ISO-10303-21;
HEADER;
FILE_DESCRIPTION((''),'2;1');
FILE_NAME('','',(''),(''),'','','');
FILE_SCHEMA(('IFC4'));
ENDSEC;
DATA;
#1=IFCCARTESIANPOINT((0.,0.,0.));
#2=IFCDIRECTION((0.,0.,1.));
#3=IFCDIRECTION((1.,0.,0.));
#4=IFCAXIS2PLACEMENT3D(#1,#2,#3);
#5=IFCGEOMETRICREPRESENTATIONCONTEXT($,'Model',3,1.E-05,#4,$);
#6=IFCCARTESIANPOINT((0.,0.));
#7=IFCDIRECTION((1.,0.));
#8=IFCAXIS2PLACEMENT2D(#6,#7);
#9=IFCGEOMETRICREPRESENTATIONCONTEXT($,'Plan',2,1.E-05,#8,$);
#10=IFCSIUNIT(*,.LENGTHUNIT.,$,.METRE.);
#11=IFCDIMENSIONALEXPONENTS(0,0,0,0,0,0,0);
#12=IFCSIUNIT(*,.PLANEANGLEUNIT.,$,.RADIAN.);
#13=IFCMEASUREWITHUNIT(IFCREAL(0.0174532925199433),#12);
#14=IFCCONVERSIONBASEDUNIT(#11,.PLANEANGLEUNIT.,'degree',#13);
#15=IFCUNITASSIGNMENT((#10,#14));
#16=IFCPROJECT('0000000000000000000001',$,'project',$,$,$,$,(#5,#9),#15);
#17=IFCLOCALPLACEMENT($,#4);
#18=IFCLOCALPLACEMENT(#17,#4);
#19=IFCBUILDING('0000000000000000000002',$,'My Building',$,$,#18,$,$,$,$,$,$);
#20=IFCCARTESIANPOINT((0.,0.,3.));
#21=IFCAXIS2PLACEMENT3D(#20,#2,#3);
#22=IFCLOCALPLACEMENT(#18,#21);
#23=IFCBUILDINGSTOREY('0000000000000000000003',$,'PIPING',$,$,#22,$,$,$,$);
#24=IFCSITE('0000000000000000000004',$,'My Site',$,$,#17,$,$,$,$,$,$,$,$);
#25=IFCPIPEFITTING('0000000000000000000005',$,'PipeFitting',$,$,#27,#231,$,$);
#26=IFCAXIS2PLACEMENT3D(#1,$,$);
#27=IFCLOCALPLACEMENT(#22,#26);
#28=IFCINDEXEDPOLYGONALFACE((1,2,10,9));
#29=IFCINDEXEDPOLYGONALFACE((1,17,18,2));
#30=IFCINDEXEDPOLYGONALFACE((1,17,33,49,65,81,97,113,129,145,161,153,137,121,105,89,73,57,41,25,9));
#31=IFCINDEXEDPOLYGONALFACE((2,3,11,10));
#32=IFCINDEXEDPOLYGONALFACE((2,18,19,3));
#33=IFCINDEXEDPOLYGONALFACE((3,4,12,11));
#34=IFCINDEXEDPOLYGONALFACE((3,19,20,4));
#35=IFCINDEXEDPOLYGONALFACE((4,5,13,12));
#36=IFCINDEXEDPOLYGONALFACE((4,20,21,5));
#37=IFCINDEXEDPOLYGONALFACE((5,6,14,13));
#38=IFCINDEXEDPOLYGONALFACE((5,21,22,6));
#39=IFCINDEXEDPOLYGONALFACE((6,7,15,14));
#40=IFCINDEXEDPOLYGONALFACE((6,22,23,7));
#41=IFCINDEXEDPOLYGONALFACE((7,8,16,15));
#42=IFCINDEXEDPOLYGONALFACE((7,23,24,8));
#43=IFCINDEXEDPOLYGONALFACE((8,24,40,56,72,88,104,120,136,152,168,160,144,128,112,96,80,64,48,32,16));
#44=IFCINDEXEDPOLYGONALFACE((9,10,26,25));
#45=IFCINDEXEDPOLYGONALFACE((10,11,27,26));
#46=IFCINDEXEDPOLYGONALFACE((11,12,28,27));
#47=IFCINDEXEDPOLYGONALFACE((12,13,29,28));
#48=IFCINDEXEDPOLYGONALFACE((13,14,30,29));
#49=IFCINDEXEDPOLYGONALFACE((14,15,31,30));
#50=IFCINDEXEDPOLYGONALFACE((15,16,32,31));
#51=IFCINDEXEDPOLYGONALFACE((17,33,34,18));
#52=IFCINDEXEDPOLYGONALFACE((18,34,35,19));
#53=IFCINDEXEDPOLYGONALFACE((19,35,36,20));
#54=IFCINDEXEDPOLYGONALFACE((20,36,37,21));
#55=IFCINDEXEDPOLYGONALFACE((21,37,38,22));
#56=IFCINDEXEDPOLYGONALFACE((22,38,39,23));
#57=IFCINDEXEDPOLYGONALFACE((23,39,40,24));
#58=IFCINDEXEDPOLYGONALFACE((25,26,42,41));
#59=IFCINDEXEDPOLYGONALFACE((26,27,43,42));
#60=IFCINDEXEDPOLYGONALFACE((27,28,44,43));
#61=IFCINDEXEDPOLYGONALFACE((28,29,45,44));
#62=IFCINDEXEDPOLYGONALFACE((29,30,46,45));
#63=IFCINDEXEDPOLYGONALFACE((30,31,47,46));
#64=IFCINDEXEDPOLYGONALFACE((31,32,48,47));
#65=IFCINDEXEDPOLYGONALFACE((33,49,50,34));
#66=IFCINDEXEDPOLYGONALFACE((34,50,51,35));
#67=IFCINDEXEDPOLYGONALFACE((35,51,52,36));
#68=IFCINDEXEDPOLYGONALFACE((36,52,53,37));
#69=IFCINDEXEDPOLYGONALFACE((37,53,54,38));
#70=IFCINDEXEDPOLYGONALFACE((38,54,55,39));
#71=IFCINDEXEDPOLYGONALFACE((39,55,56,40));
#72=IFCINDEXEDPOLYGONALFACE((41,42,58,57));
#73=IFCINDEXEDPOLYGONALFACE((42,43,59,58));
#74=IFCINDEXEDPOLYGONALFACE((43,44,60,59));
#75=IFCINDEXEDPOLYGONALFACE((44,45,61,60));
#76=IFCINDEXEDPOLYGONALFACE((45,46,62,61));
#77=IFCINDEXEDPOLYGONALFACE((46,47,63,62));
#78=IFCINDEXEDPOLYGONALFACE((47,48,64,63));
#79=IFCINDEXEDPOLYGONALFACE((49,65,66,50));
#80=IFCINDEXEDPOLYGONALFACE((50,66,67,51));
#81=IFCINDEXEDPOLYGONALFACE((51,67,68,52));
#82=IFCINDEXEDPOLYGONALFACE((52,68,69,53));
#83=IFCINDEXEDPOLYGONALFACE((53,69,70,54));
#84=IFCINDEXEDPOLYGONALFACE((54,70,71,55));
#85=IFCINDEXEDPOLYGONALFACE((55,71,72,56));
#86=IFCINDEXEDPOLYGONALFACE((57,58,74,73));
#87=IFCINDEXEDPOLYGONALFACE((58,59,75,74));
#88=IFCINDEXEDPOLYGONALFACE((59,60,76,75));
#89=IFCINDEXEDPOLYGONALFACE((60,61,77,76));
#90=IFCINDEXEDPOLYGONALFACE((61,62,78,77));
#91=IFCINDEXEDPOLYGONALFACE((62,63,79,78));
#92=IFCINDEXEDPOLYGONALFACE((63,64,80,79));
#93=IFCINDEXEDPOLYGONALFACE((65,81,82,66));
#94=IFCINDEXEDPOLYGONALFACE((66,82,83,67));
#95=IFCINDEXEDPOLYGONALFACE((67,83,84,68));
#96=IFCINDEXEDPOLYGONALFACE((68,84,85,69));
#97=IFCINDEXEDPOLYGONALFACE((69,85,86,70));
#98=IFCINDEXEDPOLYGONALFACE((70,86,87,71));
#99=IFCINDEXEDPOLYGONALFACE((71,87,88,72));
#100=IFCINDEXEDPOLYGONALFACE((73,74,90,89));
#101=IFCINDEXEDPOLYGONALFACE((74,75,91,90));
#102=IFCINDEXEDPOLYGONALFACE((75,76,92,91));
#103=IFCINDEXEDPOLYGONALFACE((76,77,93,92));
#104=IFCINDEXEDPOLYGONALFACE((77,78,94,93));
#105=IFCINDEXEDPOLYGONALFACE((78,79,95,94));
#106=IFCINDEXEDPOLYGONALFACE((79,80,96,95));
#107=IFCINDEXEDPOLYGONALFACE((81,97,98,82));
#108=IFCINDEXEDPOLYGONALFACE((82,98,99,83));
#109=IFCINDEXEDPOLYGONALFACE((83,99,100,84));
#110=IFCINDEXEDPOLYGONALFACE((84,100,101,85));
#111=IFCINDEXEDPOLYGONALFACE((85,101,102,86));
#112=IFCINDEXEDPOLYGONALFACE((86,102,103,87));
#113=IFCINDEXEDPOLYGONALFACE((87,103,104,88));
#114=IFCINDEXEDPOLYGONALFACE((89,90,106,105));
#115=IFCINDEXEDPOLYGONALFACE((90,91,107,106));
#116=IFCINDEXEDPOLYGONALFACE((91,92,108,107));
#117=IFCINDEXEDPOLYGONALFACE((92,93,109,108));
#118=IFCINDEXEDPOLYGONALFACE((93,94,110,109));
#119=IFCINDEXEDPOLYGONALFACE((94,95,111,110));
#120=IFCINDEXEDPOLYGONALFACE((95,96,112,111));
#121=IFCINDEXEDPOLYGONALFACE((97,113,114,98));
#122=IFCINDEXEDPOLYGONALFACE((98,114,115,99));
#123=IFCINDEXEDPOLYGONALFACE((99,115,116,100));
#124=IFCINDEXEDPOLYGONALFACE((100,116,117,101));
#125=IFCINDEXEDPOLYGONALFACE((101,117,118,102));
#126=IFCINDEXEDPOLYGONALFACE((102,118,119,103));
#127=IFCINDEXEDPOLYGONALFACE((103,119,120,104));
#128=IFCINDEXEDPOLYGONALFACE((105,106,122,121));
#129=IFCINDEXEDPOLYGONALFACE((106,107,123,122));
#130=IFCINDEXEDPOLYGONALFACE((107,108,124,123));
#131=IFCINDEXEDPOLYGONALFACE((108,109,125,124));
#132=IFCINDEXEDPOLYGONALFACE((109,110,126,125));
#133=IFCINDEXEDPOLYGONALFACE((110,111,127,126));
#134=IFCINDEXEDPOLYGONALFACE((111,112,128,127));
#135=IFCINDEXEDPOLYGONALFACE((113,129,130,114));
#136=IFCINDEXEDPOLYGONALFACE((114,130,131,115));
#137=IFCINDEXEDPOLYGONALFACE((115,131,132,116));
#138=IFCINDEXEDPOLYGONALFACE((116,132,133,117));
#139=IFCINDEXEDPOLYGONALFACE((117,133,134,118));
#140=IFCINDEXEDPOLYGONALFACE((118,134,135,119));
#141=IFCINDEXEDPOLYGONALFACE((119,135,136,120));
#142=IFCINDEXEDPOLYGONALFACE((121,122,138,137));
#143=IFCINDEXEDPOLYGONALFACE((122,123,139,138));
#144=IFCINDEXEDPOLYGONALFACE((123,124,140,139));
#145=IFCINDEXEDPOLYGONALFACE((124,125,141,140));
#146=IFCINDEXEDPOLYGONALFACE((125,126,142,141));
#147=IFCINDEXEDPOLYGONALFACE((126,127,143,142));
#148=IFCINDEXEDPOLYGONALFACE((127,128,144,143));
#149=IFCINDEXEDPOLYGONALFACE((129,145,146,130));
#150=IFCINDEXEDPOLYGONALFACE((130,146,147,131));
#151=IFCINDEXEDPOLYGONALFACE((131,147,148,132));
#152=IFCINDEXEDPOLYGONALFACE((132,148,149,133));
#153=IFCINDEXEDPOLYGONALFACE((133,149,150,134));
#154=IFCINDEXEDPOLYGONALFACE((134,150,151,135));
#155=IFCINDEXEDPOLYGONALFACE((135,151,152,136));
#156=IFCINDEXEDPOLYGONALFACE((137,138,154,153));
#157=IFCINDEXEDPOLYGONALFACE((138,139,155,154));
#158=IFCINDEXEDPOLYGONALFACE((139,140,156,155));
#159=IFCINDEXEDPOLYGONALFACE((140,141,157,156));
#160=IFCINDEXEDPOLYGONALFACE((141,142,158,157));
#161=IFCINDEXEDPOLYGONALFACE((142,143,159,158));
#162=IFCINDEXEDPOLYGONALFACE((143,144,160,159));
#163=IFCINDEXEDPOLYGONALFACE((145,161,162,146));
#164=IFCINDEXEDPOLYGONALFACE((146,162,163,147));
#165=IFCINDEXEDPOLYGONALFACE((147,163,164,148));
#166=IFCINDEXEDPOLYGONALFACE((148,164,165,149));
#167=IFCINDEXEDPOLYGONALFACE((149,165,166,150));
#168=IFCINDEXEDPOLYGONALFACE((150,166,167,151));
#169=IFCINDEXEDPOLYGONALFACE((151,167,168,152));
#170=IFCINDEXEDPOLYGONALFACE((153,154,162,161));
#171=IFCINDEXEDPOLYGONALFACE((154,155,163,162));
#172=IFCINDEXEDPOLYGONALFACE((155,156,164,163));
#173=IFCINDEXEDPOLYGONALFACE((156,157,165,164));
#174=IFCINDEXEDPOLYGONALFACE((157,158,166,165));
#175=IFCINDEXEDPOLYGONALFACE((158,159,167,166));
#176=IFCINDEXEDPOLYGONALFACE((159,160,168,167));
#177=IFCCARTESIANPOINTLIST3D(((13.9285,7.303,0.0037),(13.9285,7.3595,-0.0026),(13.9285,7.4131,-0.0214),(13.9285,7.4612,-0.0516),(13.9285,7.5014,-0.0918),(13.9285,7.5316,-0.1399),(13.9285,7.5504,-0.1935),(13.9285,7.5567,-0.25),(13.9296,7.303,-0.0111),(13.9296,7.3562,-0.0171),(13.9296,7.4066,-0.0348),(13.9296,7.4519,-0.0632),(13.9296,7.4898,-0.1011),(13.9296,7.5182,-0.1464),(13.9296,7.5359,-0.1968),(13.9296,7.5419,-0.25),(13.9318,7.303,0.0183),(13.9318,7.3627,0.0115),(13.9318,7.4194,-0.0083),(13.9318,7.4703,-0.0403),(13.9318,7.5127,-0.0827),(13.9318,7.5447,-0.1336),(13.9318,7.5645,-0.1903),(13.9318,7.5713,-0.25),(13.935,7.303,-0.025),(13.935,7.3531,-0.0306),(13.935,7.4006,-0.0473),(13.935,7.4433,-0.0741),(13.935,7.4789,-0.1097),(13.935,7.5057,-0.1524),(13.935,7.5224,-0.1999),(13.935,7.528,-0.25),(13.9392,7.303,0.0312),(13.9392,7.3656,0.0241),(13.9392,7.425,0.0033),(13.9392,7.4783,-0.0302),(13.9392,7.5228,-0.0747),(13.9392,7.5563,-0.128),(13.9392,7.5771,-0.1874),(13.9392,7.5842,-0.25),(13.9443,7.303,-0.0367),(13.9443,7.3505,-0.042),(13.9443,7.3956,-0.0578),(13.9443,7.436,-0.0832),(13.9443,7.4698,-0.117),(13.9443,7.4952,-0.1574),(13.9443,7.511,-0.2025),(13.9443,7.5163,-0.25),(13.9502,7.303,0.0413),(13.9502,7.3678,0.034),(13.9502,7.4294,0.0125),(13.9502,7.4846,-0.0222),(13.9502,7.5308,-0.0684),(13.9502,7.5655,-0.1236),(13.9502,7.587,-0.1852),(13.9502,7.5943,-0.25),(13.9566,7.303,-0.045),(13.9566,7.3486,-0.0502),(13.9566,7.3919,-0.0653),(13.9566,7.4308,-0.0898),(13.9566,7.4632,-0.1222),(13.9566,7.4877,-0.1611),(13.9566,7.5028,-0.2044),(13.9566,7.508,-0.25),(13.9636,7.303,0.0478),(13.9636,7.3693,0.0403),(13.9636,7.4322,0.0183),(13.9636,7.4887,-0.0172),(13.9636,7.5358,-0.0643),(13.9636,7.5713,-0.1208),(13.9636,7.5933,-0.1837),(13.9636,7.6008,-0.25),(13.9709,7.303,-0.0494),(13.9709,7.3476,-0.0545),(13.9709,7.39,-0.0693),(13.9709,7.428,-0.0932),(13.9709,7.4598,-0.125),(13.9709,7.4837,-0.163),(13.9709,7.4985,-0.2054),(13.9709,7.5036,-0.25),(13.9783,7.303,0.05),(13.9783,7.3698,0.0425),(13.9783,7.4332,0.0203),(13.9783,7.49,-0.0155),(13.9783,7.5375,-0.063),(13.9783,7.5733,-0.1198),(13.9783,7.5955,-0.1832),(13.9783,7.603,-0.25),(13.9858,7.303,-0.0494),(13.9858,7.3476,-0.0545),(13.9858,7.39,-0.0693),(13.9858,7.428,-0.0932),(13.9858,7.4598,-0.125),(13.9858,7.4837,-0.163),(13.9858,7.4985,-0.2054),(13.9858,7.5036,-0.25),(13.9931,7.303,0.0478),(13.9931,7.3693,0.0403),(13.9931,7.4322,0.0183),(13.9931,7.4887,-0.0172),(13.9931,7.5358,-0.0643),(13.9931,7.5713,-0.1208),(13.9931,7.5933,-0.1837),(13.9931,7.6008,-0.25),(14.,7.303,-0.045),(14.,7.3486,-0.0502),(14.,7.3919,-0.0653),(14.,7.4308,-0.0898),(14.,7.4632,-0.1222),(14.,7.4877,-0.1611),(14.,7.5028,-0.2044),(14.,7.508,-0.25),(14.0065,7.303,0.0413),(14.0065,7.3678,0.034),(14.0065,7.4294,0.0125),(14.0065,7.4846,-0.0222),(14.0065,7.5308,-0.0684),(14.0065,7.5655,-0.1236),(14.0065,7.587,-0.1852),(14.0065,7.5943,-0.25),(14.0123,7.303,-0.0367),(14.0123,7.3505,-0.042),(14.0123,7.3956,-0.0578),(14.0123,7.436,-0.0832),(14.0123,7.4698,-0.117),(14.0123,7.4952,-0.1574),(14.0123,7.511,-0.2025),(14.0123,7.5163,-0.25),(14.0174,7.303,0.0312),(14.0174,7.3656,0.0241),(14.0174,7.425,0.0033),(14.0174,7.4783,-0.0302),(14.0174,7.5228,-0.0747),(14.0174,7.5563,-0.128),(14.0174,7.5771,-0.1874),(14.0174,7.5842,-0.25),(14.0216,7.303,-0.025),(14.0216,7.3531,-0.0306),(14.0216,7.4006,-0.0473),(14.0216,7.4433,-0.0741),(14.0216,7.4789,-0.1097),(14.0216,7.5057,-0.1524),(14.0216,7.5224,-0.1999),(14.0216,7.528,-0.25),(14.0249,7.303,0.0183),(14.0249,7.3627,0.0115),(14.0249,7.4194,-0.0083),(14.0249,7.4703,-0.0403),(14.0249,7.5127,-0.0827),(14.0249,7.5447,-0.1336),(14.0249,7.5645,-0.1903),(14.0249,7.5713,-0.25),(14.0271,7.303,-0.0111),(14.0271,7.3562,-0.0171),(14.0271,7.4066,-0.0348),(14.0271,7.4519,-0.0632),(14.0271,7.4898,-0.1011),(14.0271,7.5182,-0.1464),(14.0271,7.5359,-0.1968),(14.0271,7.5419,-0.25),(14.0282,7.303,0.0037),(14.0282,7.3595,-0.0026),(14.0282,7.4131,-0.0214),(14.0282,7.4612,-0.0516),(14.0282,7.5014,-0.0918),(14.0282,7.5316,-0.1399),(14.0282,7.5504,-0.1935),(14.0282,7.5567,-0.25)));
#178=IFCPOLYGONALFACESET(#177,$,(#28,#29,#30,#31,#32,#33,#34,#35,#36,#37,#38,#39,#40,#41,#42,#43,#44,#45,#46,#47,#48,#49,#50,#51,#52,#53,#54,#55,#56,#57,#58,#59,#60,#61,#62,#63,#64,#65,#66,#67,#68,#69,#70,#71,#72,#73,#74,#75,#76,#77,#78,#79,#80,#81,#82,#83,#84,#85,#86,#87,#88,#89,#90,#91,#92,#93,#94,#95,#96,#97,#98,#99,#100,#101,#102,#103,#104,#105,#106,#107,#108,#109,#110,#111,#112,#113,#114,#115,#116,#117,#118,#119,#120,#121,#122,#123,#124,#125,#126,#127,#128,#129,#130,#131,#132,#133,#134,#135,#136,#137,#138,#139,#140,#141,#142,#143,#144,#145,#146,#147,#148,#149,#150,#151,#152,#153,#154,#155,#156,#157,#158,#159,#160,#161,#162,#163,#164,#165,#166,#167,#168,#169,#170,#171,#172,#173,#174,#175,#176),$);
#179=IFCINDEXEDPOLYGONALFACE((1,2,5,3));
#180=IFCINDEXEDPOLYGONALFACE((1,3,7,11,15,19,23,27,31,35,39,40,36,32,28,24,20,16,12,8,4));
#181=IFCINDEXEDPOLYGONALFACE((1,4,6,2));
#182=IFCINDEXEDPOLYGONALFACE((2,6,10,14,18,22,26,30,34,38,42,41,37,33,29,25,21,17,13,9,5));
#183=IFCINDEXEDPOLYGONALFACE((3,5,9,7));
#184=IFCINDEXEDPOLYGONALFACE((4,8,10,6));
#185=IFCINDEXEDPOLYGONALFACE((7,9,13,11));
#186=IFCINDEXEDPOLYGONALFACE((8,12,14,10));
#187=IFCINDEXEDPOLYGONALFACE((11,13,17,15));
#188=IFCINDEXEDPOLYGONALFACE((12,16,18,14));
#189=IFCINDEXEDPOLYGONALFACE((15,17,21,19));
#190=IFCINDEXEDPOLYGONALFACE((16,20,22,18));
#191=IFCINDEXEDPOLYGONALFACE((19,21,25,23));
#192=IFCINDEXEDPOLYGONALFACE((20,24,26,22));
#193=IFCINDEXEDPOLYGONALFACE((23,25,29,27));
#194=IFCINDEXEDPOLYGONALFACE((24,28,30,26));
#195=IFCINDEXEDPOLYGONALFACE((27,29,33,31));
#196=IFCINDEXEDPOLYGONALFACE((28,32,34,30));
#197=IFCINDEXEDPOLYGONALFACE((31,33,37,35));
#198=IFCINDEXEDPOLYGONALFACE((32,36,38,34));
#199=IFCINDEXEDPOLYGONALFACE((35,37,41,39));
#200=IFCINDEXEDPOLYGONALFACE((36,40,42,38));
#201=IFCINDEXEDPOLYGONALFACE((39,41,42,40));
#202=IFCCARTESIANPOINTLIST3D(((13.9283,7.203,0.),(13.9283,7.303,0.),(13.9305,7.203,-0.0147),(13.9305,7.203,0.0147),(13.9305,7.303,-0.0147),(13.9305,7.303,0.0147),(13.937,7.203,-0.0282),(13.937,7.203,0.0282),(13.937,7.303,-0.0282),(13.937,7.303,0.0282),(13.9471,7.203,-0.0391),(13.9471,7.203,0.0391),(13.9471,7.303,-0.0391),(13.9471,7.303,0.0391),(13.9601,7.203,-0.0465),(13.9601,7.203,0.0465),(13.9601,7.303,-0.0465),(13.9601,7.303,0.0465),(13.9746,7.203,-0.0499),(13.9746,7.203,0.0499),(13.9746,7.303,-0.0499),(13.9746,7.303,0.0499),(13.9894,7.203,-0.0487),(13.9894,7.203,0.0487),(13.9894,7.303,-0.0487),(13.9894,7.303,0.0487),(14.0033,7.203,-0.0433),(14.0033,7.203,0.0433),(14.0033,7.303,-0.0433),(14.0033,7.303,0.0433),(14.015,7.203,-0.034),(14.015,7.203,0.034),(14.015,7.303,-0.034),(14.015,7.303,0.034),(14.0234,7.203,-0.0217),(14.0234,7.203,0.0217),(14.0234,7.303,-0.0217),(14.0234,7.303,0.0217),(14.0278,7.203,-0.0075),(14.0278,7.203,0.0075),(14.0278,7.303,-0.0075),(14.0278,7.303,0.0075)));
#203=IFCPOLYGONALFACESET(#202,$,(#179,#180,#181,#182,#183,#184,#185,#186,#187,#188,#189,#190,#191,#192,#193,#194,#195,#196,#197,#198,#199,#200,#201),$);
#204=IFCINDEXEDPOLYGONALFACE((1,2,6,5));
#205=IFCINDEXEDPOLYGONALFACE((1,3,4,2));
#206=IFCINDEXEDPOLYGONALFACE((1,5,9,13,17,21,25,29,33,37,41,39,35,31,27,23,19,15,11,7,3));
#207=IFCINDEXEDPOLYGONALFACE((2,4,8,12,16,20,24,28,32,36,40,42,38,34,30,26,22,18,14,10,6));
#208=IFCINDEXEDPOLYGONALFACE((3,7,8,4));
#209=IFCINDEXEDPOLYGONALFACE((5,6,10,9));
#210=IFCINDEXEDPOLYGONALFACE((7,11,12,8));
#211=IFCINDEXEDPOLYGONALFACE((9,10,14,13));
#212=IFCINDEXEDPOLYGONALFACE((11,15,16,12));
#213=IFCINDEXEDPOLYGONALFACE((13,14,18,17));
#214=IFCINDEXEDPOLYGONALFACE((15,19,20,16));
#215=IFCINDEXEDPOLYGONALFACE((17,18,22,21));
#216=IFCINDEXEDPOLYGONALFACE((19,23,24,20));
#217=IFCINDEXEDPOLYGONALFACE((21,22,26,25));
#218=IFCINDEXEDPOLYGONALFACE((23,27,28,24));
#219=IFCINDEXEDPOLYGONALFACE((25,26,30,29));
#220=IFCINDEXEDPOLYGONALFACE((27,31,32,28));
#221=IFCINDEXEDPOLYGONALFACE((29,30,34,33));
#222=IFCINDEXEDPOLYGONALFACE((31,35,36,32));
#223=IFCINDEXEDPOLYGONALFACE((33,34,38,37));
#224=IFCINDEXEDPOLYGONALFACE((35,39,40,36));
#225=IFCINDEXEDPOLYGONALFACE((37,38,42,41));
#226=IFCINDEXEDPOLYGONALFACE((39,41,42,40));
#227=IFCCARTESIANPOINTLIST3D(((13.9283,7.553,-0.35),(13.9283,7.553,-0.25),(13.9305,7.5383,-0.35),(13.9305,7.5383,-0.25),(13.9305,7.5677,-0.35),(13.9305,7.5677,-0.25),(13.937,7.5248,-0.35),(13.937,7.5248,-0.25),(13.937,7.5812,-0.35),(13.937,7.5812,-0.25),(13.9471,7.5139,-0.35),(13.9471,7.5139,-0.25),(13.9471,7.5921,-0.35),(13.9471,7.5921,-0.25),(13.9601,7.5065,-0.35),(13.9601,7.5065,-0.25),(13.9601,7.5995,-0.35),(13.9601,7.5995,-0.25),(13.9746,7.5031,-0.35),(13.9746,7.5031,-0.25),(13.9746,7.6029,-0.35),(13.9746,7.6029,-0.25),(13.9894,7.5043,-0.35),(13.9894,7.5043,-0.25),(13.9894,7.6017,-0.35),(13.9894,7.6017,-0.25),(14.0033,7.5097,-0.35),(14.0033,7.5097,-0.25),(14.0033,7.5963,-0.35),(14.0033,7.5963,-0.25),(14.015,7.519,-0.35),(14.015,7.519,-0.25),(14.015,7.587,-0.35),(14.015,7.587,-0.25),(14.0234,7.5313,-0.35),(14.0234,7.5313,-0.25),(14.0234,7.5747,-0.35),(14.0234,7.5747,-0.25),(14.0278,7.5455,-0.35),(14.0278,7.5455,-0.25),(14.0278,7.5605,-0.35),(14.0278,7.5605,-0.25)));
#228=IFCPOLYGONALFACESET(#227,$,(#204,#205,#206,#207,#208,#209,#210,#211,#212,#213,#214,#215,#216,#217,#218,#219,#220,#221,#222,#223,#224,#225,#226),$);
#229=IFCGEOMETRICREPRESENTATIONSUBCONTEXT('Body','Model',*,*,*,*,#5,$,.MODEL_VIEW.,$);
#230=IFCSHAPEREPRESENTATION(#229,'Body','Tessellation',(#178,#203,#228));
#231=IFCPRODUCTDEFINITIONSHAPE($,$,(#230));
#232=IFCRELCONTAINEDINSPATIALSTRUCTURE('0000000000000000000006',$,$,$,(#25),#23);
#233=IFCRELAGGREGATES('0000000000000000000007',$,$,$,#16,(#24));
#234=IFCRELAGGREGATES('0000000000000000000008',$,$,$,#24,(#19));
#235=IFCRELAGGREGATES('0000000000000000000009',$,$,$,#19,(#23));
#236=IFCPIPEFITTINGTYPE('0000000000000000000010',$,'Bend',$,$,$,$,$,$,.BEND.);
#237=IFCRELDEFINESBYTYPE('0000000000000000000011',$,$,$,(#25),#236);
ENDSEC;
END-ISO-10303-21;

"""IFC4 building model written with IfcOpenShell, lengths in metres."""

from ifc_helpers import new_model, entity, si_unit, converted_unit, frame, origin_with_axes, origin_2d_with_axis, place, context, subcontext, project, spatial, line, indexed_curve, circle, outline, extrude, source, transform, mapped, type_object, type_shapes, element, save


model = new_model("IFC4")

# Units and contexts
model_context = context("Model", 3, precision=1e-05, world=origin_with_axes())
plan_context = context("Plan", 2, precision=1e-05, world=origin_2d_with_axis())
body_context = subcontext(model_context, "Body", "Model", "MODEL_VIEW")
ifc_project = project(units=[si_unit("LENGTHUNIT", "METRE"), converted_unit("PLANEANGLEUNIT", "degree", entity("IfcReal", 0.0174532925199433), si_unit("PLANEANGLEUNIT", "RADIAN"), dimensions=[0, 0, 0, 0, 0, 0, 0])], contexts=[model_context, plan_context])

# Site, building, storey
site_placement = place(None, origin_with_axes())
site = spatial("IfcSite", under=ifc_project, at=site_placement, Name="My Site")
building_placement = place(site_placement, origin_with_axes())
building = spatial("IfcBuilding", under=site, at=building_placement, Name="My Building")
storey_placement = place(building_placement, frame((0.0, 0.0, 3.0), z_axis=(0.0, 0.0, 1.0), x_axis=(1.0, 0.0, 0.0)))
storey = spatial("IfcBuildingStorey", under=building, at=storey_placement, Name="PIPING")

# Shared definitions
pipe_fitting_type = type_object("IfcPipeFittingType", Name="Bend", PredefinedType="BEND")
shared_shape = source(origin_with_axes(), body_context, "Body", "SolidModel", [
    entity("IfcSweptDiskSolid", entity("IfcIndexedPolyCurve", entity("IfcCartesianPointList3D", [[0.0, 0.0, -0.1], [0.0, 0.0732, -0.2768], [0.0, 0.25, -0.35]]), [entity("IfcArcIndex", [1, 2, 3])]), 0.05),
    extrude(circle(Radius=0.05), origin_with_axes(), (0.0, 0.0, -1.0), 0.1),
    extrude(circle(Radius=0.05), frame((0.0, 0.25, -0.35), z_axis=(0.0, 1.0, 0.0), x_axis=(1.0, 0.0, 0.0)), (0.0, 0.0, 1.0), 0.1),
])
type_shapes(pipe_fitting_type, [shared_shape])

# Pipe fitting, opening
pipe_fitting_1_placement = place(storey_placement, frame((13.9783, 7.203, 0.0), z_axis=(0.0, -1.0, 0.0), x_axis=(-1.0, 0.0, 0.0)))
pipe_fitting_1 = element("IfcPipeFitting", 1, at=pipe_fitting_1_placement, inside=storey, type_object=pipe_fitting_type, Name="PipeFitting", context=body_context, shape_type="MappedRepresentation", body=[
    mapped(shared_shape, transform((0.0, 0.0, 0.0), x_axis=(1.0, 0.0, 0.0), y_axis=(0.0, 1.0, 0.0), z_axis=(0.0, 0.0, 1.0), scale=1.0)),
])
opening_1_placement = place(pipe_fitting_1_placement, frame((14.1739, 3.0, 7.203), z_axis=(0.0, -1.0, 0.0), x_axis=(-1.0, 0.0, 0.0)))
element("IfcOpeningElement", 2, at=opening_1_placement, cuts=pipe_fitting_1, PredefinedType="OPENING", context=body_context, shape_type="SweptSolid", body=[
    extrude(outline(indexed_curve([(0.0, 0.0), (0.5, 0.0), (0.5, 0.5), (0.0, 0.5)], segments=[line(1, 2, 3, 4, 1)])), origin_with_axes(), (0.0, 0.0, 1.0), 0.5),
])

save(model, "model.ifc")
